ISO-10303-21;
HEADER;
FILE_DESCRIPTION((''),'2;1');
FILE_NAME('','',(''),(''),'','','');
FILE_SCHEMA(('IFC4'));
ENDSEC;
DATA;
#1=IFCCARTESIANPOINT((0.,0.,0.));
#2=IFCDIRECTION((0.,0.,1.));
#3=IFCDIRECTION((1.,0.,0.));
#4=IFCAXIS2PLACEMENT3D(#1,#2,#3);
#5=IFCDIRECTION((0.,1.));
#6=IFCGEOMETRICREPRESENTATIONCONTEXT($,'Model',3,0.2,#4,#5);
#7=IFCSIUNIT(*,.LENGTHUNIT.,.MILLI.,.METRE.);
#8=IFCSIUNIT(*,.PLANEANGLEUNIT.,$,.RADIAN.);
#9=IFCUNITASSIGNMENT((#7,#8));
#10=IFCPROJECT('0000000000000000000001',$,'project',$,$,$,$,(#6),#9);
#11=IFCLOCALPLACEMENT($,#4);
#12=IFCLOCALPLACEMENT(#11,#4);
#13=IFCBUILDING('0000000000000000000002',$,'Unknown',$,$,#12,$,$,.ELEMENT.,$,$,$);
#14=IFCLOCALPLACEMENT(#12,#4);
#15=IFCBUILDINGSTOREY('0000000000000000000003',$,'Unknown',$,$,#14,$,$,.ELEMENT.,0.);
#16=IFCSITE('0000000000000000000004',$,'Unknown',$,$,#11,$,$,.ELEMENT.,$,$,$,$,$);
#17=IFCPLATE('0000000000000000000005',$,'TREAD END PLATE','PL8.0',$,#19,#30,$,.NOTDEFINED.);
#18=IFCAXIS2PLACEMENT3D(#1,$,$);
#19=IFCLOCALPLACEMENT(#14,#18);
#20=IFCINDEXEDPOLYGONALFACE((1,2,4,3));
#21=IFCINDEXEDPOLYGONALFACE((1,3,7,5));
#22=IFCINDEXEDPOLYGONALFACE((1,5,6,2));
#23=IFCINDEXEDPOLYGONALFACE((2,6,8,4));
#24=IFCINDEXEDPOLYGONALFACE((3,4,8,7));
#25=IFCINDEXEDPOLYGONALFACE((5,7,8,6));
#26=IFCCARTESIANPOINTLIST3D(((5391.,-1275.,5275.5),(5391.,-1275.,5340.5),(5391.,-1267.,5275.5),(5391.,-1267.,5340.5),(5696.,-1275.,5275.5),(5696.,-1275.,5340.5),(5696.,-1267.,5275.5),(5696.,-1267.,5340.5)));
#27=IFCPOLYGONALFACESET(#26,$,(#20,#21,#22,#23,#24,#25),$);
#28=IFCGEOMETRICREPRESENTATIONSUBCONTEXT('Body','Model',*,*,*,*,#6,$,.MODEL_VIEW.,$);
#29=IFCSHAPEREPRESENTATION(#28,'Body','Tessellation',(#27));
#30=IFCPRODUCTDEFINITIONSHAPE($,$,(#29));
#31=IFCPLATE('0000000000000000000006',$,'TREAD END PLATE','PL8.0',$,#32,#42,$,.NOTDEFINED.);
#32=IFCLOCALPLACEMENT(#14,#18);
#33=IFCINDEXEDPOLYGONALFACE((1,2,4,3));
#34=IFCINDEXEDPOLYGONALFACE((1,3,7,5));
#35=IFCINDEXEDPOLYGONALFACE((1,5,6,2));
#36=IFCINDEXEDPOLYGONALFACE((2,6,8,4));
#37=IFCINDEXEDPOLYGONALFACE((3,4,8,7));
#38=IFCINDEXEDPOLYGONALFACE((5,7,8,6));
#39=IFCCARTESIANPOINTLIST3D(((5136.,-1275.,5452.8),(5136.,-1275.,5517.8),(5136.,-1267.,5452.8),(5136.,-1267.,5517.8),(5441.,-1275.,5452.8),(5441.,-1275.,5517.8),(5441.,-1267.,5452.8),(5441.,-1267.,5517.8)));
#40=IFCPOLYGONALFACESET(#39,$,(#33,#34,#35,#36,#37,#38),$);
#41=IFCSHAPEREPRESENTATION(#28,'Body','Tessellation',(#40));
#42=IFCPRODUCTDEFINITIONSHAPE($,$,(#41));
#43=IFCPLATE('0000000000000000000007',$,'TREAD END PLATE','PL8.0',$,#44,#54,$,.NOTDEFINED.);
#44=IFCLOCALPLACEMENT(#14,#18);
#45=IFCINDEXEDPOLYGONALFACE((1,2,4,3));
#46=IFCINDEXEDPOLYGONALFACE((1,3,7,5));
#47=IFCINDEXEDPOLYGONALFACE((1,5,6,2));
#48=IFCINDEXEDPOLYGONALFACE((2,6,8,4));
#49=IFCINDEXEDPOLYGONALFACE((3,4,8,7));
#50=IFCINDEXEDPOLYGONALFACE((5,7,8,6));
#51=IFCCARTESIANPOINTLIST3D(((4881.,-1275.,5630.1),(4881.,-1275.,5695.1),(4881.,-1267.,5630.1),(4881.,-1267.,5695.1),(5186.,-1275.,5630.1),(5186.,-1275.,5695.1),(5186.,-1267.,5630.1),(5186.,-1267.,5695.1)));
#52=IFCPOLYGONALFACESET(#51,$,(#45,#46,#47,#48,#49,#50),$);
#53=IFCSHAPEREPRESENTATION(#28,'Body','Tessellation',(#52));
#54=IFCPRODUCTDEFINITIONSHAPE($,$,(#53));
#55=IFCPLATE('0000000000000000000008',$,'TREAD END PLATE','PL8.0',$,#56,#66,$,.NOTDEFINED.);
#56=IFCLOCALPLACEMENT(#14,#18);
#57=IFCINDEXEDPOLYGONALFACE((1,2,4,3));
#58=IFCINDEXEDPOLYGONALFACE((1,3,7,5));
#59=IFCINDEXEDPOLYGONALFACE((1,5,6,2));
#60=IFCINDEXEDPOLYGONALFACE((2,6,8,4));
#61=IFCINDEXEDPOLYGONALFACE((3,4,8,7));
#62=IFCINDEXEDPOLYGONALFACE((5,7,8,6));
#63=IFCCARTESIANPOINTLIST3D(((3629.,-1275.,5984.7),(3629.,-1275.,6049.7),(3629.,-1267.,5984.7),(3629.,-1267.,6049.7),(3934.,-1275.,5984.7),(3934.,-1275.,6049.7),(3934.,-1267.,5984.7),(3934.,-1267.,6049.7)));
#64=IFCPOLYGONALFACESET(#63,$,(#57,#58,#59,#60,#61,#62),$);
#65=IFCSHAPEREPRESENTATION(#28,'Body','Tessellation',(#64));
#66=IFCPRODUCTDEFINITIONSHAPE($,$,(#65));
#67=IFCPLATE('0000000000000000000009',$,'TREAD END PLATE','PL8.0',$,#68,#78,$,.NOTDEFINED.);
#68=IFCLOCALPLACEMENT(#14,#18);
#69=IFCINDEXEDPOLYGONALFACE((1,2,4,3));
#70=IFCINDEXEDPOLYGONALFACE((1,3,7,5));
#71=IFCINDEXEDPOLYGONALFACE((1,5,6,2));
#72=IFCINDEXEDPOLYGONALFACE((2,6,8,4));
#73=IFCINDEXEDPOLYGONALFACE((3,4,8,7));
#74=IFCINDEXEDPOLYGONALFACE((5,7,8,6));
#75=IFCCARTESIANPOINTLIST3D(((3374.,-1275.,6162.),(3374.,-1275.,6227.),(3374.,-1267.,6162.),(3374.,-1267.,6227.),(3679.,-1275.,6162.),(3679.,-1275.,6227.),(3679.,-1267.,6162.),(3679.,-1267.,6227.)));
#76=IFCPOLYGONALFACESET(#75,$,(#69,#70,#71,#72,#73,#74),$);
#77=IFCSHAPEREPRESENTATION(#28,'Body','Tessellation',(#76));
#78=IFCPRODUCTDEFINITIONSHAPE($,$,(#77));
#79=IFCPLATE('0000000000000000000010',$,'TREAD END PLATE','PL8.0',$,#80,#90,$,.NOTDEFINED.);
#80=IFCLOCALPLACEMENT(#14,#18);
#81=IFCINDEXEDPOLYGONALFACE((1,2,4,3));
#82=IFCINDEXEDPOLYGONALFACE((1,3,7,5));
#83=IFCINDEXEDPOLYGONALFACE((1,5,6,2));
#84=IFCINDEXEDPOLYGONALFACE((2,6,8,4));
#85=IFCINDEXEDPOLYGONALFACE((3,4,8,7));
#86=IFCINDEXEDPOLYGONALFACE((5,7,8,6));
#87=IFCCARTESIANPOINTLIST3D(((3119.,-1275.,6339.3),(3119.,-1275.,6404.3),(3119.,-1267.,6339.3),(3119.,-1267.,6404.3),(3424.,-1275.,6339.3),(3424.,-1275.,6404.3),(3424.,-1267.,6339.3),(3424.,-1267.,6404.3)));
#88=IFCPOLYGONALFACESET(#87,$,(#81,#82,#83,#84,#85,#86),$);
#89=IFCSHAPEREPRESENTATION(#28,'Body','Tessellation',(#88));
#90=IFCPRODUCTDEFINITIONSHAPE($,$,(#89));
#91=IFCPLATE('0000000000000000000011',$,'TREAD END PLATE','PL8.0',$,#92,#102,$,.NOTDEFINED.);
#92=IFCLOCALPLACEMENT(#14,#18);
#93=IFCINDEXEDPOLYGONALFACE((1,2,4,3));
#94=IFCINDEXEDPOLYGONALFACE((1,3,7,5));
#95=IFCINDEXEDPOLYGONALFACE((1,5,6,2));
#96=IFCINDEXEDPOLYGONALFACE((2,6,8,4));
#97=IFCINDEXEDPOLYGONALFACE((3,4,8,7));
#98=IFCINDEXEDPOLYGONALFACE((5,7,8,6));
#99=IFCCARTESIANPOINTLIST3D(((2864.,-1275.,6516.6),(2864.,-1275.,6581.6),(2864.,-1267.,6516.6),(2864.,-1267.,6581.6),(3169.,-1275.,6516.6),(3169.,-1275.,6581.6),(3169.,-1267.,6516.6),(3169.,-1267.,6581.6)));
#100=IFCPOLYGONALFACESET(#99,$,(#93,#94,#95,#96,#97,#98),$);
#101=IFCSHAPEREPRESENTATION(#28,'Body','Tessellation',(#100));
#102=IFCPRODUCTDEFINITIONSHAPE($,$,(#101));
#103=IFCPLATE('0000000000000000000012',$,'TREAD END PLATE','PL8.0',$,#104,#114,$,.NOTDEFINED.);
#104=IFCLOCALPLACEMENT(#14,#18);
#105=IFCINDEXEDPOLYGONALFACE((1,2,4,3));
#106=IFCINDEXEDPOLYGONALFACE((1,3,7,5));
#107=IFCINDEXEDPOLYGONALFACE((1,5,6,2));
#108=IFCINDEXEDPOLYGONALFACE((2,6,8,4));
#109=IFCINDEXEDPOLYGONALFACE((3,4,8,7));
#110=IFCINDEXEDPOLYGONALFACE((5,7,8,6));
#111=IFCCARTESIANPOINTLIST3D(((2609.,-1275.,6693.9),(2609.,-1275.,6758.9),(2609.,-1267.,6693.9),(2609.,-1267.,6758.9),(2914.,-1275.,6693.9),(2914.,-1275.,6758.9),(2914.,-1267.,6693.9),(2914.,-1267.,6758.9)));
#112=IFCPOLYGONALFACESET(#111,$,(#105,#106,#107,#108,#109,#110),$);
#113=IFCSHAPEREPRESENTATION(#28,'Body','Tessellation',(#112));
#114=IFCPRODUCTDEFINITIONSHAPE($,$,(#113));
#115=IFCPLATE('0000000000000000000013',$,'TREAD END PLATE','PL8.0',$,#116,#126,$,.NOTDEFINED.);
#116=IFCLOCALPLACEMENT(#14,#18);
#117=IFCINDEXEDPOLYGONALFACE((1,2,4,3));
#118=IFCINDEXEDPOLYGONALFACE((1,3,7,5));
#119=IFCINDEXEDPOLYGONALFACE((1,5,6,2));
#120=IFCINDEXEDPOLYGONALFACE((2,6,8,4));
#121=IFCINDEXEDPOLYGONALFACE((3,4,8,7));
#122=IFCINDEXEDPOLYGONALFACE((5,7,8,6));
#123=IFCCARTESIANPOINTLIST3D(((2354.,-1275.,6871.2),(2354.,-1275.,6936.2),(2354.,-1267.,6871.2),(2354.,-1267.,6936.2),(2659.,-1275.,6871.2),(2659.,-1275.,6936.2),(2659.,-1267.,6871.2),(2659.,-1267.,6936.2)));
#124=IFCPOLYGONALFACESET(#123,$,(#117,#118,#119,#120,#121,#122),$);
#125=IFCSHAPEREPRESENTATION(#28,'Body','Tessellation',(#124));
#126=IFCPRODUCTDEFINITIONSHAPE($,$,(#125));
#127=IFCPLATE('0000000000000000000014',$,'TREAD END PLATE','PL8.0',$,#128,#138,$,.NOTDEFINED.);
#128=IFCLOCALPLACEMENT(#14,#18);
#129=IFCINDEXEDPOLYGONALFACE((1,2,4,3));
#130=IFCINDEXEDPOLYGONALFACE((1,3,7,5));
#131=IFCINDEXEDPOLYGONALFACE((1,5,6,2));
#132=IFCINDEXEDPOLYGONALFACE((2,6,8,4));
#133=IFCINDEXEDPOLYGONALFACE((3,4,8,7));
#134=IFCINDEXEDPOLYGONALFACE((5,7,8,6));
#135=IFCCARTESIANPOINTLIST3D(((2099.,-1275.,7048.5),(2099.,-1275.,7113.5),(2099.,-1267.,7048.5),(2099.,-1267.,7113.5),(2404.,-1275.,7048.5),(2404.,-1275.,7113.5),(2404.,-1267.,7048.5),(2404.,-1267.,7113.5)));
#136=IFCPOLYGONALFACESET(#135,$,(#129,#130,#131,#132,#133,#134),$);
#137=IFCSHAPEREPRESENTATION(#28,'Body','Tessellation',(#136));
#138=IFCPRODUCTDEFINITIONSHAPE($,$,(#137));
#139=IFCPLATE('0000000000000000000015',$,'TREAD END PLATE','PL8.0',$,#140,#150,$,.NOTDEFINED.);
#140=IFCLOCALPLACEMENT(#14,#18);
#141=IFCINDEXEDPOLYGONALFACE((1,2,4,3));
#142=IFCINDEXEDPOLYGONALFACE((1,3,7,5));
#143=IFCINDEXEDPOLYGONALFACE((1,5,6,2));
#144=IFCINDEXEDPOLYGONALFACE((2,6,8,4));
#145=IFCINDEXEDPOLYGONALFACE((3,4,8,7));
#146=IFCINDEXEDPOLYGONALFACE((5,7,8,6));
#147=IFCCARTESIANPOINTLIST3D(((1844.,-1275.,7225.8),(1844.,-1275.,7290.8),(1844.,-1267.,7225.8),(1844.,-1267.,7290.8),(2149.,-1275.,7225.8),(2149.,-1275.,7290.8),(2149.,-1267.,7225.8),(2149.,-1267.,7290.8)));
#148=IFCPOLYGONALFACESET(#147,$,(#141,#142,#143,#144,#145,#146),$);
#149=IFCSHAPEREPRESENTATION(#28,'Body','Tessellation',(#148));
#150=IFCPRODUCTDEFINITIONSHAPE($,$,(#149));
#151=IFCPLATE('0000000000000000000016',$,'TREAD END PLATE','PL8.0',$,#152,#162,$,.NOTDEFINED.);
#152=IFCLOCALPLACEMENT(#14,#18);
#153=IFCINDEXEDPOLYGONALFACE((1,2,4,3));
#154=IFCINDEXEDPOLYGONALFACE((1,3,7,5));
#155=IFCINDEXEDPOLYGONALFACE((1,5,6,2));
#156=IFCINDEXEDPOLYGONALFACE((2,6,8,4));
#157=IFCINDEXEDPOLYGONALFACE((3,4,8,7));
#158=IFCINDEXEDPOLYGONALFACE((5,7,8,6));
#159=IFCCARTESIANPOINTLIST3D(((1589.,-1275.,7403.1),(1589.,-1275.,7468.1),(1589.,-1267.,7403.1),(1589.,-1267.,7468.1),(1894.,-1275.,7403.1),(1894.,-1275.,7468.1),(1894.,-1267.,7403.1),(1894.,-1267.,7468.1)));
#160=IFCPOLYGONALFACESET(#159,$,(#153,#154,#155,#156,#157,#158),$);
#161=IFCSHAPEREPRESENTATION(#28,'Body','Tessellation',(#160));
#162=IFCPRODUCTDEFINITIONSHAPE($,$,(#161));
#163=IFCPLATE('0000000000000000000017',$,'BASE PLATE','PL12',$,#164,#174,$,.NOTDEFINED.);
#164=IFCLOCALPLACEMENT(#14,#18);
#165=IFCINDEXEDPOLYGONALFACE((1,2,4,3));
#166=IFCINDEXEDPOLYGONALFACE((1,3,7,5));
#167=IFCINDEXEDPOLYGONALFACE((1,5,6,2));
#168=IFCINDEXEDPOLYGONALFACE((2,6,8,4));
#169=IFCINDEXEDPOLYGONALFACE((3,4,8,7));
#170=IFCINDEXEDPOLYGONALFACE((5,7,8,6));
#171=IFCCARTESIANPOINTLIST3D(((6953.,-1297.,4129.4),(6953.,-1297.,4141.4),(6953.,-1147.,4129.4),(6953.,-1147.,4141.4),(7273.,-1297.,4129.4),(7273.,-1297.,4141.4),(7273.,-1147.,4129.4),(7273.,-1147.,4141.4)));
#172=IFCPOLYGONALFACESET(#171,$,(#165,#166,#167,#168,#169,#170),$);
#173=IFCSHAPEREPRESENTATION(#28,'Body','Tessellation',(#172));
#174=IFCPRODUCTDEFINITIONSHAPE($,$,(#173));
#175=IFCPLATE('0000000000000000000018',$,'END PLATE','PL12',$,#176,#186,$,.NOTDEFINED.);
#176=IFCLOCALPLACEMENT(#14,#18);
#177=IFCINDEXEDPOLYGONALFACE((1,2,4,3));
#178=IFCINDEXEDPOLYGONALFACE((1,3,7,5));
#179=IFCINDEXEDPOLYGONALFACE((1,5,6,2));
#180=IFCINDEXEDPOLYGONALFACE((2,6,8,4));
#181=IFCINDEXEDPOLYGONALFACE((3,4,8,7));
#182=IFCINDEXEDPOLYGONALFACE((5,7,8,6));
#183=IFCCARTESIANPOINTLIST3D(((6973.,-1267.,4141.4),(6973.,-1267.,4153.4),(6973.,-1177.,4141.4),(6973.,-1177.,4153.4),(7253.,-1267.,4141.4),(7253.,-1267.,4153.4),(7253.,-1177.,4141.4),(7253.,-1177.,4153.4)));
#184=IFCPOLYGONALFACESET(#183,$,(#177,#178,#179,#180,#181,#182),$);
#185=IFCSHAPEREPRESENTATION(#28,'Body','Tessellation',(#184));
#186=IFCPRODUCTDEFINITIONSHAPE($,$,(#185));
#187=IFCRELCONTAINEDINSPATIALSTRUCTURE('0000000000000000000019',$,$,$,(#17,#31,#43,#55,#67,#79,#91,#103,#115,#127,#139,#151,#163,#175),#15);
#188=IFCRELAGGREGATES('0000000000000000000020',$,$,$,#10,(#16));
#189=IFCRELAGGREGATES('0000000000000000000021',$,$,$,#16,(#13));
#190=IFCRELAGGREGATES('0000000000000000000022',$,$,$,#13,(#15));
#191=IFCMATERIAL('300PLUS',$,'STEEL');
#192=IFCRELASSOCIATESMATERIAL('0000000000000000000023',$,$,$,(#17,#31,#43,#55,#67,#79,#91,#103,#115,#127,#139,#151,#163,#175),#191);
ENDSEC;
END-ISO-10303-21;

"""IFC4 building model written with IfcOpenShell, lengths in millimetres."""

from ifc_helpers import new_model, si_unit, direction, frame, origin_with_axes, place, context, subcontext, project, spatial, line, indexed_curve, outline, extrude, material, element, save


model = new_model("IFC4")

# Units and contexts
model_context = context("Model", 3, precision=0.2, world=origin_with_axes(), true_north=direction((0.0, 1.0)))
body_context = subcontext(model_context, "Body", "Model", "MODEL_VIEW")
ifc_project = project(units=[si_unit("LENGTHUNIT", "METRE", prefix="MILLI"), si_unit("PLANEANGLEUNIT", "RADIAN")], contexts=[model_context])

# Site, building, storey
site_placement = place(None, origin_with_axes())
site = spatial("IfcSite", under=ifc_project, at=site_placement, Name="Unknown", CompositionType="ELEMENT")
building_placement = place(site_placement, origin_with_axes())
building = spatial("IfcBuilding", under=site, at=building_placement, Name="Unknown", CompositionType="ELEMENT")
storey_placement = place(building_placement, origin_with_axes())
storey = spatial("IfcBuildingStorey", under=building, at=storey_placement, Name="Unknown", CompositionType="ELEMENT", Elevation=0.0)

# Shared definitions
ifc_material_1 = material(Name="300PLUS", Category="STEEL")

# Plates
for number, where, z_axis, x_axis, name in (
    (1, (5391.0, -1271.0, 5275.5), (0.0, -1.0, 0.0), (1.0, 0.0, 0.0), "TREAD END PLATE"),
    (2, (5136.0, -1271.0, 5452.8), (0.0, -1.0, 0.0), (1.0, 0.0, 0.0), "TREAD END PLATE"),
    (3, (4881.0, -1271.0, 5630.1), (0.0, -1.0, 0.0), (1.0, 0.0, 0.0), "TREAD END PLATE"),
    (4, (3629.0, -1271.0, 5984.7), (0.0, -1.0, 0.0), (1.0, 0.0, 0.0), "TREAD END PLATE"),
    (5, (3374.0, -1271.0, 6162.0), (0.0, -1.0, 0.0), (1.0, 0.0, 0.0), "TREAD END PLATE"),
    (6, (3119.0, -1271.0, 6339.3), (0.0, -1.0, 0.0), (1.0, 0.0, 0.0), "TREAD END PLATE"),
    (7, (2864.0, -1271.0, 6516.6), (0.0, -1.0, 0.0), (1.0, 0.0, 0.0), "TREAD END PLATE"),
    (8, (2609.0, -1271.0, 6693.9), (0.0, -1.0, 0.0), (1.0, 0.0, 0.0), "TREAD END PLATE"),
    (9, (2354.0, -1271.0, 6871.2), (0.0, -1.0, 0.0), (1.0, 0.0, 0.0), "TREAD END PLATE"),
    (10, (2099.0, -1271.0, 7048.5), (0.0, -1.0, 0.0), (1.0, 0.0, 0.0), "TREAD END PLATE"),
    (11, (1844.0, -1271.0, 7225.8), (0.0, -1.0, 0.0), (1.0, 0.0, 0.0), "TREAD END PLATE"),
    (12, (1589.0, -1271.0, 7403.1), (0.0, -1.0, 0.0), (1.0, 0.0, 0.0), "TREAD END PLATE"),
):
    element("IfcPlate", number, at=place(storey_placement, frame(where, z_axis=z_axis, x_axis=x_axis)), inside=storey, material=ifc_material_1, Name=name, Description="PL8.0", PredefinedType="NOTDEFINED", context=body_context, shape_type="SolidModel", body=[
        extrude(outline(indexed_curve([(0.0, 0.0), (305.0, 0.0), (305.0, 65.0), (0.0, 65.0)], segments=[line(1, 2, 3, 4, 1)])), frame((0.0, 0.0, 4.0), z_axis=(0.0, 0.0, 1.0), x_axis=(1.0, 0.0, 0.0)), (0.0, 0.0, -1.0), 8.0),
    ])
plate_1_placement = place(storey_placement, frame((6953.0, -1297.0, 4135.4), z_axis=(0.0, 0.0, 1.0), x_axis=(1.0, 0.0, 0.0)))
element("IfcPlate", 13, at=plate_1_placement, inside=storey, material=ifc_material_1, Name="BASE PLATE", Description="PL12", PredefinedType="NOTDEFINED", context=body_context, shape_type="SolidModel", body=[
    extrude(outline(indexed_curve([(0.0, 0.0), (320.0, 0.0), (320.0, 150.0), (0.0, 150.0)], segments=[line(1, 2, 3, 4, 1)])), frame((0.0, 0.0, 6.0), z_axis=(0.0, 0.0, 1.0), x_axis=(1.0, 0.0, 0.0)), (0.0, 0.0, -1.0), 12.0),
])
plate_2_placement = place(storey_placement, frame((6973.0, -1267.0, 4147.4), z_axis=(0.0, 0.0, 1.0), x_axis=(1.0, 0.0, 0.0)))
element("IfcPlate", 14, at=plate_2_placement, inside=storey, material=ifc_material_1, Name="END PLATE", Description="PL12", PredefinedType="NOTDEFINED", context=body_context, shape_type="SolidModel", body=[
    extrude(outline(indexed_curve([(0.0, 0.0), (280.0, 0.0), (280.0, 90.0), (0.0, 90.0)], segments=[line(1, 2, 3, 4, 1)])), frame((0.0, 0.0, 6.0), z_axis=(0.0, 0.0, 1.0), x_axis=(1.0, 0.0, 0.0)), (0.0, 0.0, -1.0), 12.0),
])

save(model, "model.ifc")
